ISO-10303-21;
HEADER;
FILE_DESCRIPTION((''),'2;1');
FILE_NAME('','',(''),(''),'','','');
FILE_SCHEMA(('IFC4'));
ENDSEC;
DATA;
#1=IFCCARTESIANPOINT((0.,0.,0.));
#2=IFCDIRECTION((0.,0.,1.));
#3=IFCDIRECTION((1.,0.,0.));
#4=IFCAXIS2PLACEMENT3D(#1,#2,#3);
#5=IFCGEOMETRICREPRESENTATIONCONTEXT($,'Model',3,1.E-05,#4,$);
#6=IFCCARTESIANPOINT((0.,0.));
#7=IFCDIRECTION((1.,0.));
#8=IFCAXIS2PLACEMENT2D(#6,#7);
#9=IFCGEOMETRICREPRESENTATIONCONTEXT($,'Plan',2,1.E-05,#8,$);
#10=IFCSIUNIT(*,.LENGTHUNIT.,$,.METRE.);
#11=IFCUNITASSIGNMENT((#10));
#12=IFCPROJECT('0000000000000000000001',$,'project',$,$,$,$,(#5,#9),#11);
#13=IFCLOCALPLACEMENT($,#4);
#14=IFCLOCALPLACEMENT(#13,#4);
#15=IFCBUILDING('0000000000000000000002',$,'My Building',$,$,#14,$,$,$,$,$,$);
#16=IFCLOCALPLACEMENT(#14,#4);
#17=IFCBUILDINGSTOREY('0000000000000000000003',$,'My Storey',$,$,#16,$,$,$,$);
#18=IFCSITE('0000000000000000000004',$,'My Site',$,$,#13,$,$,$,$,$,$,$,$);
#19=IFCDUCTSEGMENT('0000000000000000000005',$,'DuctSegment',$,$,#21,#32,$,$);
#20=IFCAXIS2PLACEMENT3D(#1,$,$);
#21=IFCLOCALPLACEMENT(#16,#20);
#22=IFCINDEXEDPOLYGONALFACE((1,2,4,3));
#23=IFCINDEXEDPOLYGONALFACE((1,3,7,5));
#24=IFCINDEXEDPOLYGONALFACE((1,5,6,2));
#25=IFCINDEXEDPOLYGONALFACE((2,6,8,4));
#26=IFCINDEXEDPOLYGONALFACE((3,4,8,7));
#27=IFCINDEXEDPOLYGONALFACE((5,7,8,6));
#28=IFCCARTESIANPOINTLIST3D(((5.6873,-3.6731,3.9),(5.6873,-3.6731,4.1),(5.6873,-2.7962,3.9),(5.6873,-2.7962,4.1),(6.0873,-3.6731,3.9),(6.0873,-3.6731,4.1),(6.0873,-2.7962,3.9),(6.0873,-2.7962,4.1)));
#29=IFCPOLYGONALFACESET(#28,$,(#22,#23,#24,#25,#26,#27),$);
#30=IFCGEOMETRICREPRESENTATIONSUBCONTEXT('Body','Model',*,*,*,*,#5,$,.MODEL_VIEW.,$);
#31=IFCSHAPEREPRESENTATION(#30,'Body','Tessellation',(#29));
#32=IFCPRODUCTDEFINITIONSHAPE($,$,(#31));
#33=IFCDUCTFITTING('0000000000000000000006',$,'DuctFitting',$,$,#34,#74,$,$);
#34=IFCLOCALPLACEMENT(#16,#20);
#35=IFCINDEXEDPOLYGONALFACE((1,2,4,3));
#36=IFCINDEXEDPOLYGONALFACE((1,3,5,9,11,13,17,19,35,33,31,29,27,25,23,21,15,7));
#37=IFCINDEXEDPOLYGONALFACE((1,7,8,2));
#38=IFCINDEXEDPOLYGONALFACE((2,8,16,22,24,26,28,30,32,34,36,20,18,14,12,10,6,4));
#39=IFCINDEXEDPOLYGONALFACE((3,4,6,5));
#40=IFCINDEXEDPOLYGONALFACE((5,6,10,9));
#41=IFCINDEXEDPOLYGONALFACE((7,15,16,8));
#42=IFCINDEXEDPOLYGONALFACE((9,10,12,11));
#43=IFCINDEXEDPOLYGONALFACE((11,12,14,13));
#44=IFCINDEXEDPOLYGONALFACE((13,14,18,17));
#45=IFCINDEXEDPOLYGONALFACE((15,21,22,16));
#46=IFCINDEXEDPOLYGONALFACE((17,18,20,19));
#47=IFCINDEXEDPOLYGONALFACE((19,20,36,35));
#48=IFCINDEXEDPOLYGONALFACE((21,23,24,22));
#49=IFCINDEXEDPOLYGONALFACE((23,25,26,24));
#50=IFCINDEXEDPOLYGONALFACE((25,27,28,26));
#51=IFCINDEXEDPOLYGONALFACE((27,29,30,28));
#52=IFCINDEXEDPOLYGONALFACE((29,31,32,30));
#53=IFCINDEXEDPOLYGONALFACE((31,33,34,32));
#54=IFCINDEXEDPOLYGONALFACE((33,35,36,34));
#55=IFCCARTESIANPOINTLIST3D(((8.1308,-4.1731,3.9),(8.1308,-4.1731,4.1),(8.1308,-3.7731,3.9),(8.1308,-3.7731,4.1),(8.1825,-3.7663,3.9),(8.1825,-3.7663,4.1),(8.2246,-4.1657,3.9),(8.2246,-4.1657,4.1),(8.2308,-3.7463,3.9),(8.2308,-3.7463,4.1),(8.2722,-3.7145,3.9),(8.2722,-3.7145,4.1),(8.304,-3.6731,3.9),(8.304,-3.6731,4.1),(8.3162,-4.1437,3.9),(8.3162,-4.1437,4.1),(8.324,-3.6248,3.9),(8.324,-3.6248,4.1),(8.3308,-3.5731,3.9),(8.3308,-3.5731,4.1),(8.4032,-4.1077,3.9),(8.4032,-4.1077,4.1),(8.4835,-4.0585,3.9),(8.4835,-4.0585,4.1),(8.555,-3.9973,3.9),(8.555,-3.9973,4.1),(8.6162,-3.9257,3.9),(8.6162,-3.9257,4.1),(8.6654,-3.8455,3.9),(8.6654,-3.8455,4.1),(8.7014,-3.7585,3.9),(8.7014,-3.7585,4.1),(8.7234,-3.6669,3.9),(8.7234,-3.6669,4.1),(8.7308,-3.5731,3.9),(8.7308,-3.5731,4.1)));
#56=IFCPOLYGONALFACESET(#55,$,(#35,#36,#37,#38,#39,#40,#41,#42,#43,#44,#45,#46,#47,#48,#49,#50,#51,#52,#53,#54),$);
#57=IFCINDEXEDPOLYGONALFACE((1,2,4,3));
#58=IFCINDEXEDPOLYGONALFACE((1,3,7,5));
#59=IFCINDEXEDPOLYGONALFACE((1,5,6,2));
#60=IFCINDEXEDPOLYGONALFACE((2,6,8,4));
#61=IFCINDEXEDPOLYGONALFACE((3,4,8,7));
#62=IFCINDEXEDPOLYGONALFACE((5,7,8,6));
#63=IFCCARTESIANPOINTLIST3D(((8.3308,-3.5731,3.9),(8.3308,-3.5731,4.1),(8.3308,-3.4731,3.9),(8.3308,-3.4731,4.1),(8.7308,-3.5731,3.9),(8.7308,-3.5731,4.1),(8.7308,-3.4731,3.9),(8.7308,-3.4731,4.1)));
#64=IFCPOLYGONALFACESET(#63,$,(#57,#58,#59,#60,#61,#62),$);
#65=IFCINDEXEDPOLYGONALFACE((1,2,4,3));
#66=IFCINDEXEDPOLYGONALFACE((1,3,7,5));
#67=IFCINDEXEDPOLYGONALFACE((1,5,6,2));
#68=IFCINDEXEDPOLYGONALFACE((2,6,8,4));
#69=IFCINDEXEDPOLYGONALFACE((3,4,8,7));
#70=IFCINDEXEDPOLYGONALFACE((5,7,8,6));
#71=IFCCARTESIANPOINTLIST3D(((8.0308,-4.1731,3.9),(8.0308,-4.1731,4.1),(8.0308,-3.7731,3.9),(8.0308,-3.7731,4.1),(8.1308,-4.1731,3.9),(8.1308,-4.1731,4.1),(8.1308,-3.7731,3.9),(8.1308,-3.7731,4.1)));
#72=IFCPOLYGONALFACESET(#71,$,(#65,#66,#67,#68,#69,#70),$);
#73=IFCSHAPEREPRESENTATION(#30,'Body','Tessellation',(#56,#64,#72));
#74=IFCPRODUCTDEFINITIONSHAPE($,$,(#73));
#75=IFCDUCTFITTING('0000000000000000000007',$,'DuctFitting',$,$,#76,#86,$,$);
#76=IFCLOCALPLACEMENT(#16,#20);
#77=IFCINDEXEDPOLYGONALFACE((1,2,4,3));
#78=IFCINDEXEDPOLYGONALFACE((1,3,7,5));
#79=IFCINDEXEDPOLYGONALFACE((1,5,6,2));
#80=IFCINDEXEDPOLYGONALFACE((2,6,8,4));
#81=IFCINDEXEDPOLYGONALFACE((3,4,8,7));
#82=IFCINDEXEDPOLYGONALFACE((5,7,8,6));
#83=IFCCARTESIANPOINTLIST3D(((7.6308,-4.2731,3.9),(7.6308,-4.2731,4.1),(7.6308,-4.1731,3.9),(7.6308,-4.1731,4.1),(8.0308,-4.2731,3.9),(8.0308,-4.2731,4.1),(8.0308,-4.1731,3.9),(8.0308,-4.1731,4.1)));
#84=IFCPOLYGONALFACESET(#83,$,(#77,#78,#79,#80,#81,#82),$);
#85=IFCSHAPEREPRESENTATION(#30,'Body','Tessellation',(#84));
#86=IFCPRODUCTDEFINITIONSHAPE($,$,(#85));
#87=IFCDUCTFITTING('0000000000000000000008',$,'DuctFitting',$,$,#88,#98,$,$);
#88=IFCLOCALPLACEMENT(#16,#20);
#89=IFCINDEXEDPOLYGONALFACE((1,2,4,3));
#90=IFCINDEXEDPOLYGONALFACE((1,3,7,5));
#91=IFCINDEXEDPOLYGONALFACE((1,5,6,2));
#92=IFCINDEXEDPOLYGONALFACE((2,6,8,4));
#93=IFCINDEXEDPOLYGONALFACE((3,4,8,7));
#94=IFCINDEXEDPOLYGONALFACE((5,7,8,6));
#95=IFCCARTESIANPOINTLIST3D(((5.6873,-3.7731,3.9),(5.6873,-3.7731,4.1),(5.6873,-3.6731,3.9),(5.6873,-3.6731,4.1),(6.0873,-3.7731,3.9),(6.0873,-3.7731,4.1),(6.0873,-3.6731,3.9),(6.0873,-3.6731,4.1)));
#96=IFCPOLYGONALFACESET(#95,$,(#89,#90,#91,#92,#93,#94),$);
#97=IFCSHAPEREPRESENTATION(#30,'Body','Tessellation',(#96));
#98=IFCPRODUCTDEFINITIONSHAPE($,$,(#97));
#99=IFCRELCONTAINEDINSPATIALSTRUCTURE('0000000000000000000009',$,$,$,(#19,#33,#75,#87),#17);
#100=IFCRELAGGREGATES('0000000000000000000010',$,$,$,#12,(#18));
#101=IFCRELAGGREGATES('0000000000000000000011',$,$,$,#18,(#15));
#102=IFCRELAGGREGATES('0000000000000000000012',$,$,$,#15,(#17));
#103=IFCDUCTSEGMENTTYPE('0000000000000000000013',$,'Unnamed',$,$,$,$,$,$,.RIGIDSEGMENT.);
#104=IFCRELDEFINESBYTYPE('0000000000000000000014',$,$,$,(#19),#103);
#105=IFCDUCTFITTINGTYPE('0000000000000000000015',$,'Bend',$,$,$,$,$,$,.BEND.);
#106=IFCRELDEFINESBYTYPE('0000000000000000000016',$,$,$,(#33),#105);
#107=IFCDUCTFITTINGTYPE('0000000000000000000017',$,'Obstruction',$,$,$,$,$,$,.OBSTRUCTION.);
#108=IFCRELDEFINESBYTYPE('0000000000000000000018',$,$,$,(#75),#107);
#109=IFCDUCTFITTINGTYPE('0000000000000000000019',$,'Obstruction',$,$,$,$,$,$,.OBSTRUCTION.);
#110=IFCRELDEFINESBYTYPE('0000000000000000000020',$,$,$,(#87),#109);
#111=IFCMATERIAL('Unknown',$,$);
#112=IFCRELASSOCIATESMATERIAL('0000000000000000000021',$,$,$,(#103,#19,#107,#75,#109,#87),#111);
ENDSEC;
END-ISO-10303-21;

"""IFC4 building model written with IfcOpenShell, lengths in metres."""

from ifc_helpers import new_model, si_unit, frame, origin_with_axes, origin_2d_with_axis, place, context, subcontext, project, spatial, line, arc, indexed_curve, rectangle, outline, extrude, source, transform, mapped, material, material_profile, profile_set, profile_usage, type_object, type_shapes, element, save


model = new_model("IFC4")

# Units and contexts
model_context = context("Model", 3, precision=1e-05, world=origin_with_axes())
plan_context = context("Plan", 2, precision=1e-05, world=origin_2d_with_axis())
body_context_1 = subcontext(model_context, "Body", "Model", "MODEL_VIEW")
ifc_project = project(units=[si_unit("LENGTHUNIT", "METRE")], contexts=[model_context, plan_context])

# Site, building, storey
site_placement = place(None, origin_with_axes())
site = spatial("IfcSite", under=ifc_project, at=site_placement, Name="My Site")
building_placement = place(site_placement, origin_with_axes())
building = spatial("IfcBuilding", under=site, at=building_placement, Name="My Building")
storey_placement = place(building_placement, origin_with_axes())
storey = spatial("IfcBuildingStorey", under=building, at=storey_placement, Name="My Storey")

# Shared definitions
ifc_material = material(Name="Unknown")

# Duct segment
ifc_material_profile_1 = material_profile(ifc_material, rectangle(XDim=0.4, YDim=0.2))
ifc_profile_set_1 = profile_set([ifc_material_profile_1])
duct_segment_type = type_object("IfcDuctSegmentType", Name="Unnamed", PredefinedType="RIGIDSEGMENT", material=ifc_profile_set_1)
ifc_profile_usage_1 = profile_usage(ifc_profile_set_1, cardinal=5)
duct_segment_1_placement = place(storey_placement, frame((5.8873, -3.6731, 4.0), z_axis=(0.0, 1.0, 0.0), x_axis=(-1.0, 0.0, 0.0)))
element("IfcDuctSegment", 1, at=duct_segment_1_placement, inside=storey, type_object=duct_segment_type, material=ifc_profile_usage_1, Name="DuctSegment", context=body_context_1, shape_type="SweptSolid", body=[
    extrude(rectangle(XDim=0.4, YDim=0.2), origin_with_axes(), (0.0, 0.0, 1.0), 0.8769),
])

# Duct fittings
duct_fitting_type_1 = type_object("IfcDuctFittingType", Name="Bend", PredefinedType="BEND")
shared_shape_1 = source(origin_with_axes(), body_context_1, "Body", "SweptSolid", [
    extrude(outline(indexed_curve([(-0.2, 0.0), (-0.2586, 0.1414), (-0.4, 0.2), (-0.4, 0.6), (0.0243, 0.4243), (0.2, 0.0)], segments=[arc(1, 2, 3), line(3, 4), arc(4, 5, 6), line(6, 1)])), frame((0.0, -0.1, 0.1), z_axis=(0.0, -1.0, 0.0), x_axis=(1.0, 0.0, 0.0)), (0.0, 0.0, -1.0), 0.2),
    extrude(rectangle(XDim=0.4, YDim=0.2), origin_with_axes(), (0.0, 0.0, 1.0), 0.1),
    extrude(rectangle(XDim=0.4, YDim=0.2), frame((-0.4, 0.0, 0.5), z_axis=(-1.0, 0.0, 0.0), x_axis=(0.0, 0.0, -1.0)), (0.0, 0.0, 1.0), 0.1),
])
type_shapes(duct_fitting_type_1, [shared_shape_1])
duct_fitting_1_placement = place(storey_placement, frame((8.5308, -3.4731, 4.0), z_axis=(0.0, -1.0, 0.0), x_axis=(1.0, 0.0, 0.0)))
element("IfcDuctFitting", 2, at=duct_fitting_1_placement, inside=storey, type_object=duct_fitting_type_1, Name="DuctFitting", context=body_context_1, shape_type="MappedRepresentation", body=[
    mapped(shared_shape_1, transform((0.0, 0.0, 0.0), x_axis=(1.0, 0.0, 0.0), y_axis=(0.0, 1.0, 0.0), z_axis=(0.0, 0.0, 1.0), scale=1.0)),
])
ifc_material_profile_2 = material_profile(ifc_material, rectangle(XDim=0.4, YDim=0.2))
ifc_profile_set_2 = profile_set([ifc_material_profile_2])
ifc_profile_usage_2 = profile_usage(ifc_profile_set_2, cardinal=5)
duct_fitting_type_2 = type_object("IfcDuctFittingType", Name="Obstruction", PredefinedType="OBSTRUCTION", material=ifc_profile_set_2)
duct_fitting_2_placement = place(storey_placement, frame((7.8308, -4.1731, 4.0), z_axis=(0.0, -1.0, 0.0), x_axis=(1.0, 0.0, 0.0)))
element("IfcDuctFitting", 3, at=duct_fitting_2_placement, inside=storey, type_object=duct_fitting_type_2, material=ifc_profile_usage_2, Name="DuctFitting", context=body_context_1, shape_type="SweptSolid", body=[
    extrude(rectangle(XDim=0.4, YDim=0.2), origin_with_axes(), (0.0, 0.0, 1.0), 0.1),
])
ifc_material_profile_3 = material_profile(ifc_material, rectangle(XDim=0.4, YDim=0.2))
ifc_profile_set_3 = profile_set([ifc_material_profile_3])
ifc_profile_usage_3 = profile_usage(ifc_profile_set_3, cardinal=5)
duct_fitting_type_3 = type_object("IfcDuctFittingType", Name="Obstruction", PredefinedType="OBSTRUCTION", material=ifc_profile_set_3)
duct_fitting_3_placement = place(storey_placement, frame((5.8873, -3.7731, 4.0), z_axis=(0.0, 1.0, 0.0), x_axis=(-1.0, 0.0, 0.0)))
element("IfcDuctFitting", 4, at=duct_fitting_3_placement, inside=storey, type_object=duct_fitting_type_3, material=ifc_profile_usage_3, Name="DuctFitting", context=body_context_1, shape_type="SweptSolid", body=[
    extrude(rectangle(XDim=0.4, YDim=0.2), origin_with_axes(), (0.0, 0.0, 1.0), 0.1),
])

save(model, "model.ifc")
